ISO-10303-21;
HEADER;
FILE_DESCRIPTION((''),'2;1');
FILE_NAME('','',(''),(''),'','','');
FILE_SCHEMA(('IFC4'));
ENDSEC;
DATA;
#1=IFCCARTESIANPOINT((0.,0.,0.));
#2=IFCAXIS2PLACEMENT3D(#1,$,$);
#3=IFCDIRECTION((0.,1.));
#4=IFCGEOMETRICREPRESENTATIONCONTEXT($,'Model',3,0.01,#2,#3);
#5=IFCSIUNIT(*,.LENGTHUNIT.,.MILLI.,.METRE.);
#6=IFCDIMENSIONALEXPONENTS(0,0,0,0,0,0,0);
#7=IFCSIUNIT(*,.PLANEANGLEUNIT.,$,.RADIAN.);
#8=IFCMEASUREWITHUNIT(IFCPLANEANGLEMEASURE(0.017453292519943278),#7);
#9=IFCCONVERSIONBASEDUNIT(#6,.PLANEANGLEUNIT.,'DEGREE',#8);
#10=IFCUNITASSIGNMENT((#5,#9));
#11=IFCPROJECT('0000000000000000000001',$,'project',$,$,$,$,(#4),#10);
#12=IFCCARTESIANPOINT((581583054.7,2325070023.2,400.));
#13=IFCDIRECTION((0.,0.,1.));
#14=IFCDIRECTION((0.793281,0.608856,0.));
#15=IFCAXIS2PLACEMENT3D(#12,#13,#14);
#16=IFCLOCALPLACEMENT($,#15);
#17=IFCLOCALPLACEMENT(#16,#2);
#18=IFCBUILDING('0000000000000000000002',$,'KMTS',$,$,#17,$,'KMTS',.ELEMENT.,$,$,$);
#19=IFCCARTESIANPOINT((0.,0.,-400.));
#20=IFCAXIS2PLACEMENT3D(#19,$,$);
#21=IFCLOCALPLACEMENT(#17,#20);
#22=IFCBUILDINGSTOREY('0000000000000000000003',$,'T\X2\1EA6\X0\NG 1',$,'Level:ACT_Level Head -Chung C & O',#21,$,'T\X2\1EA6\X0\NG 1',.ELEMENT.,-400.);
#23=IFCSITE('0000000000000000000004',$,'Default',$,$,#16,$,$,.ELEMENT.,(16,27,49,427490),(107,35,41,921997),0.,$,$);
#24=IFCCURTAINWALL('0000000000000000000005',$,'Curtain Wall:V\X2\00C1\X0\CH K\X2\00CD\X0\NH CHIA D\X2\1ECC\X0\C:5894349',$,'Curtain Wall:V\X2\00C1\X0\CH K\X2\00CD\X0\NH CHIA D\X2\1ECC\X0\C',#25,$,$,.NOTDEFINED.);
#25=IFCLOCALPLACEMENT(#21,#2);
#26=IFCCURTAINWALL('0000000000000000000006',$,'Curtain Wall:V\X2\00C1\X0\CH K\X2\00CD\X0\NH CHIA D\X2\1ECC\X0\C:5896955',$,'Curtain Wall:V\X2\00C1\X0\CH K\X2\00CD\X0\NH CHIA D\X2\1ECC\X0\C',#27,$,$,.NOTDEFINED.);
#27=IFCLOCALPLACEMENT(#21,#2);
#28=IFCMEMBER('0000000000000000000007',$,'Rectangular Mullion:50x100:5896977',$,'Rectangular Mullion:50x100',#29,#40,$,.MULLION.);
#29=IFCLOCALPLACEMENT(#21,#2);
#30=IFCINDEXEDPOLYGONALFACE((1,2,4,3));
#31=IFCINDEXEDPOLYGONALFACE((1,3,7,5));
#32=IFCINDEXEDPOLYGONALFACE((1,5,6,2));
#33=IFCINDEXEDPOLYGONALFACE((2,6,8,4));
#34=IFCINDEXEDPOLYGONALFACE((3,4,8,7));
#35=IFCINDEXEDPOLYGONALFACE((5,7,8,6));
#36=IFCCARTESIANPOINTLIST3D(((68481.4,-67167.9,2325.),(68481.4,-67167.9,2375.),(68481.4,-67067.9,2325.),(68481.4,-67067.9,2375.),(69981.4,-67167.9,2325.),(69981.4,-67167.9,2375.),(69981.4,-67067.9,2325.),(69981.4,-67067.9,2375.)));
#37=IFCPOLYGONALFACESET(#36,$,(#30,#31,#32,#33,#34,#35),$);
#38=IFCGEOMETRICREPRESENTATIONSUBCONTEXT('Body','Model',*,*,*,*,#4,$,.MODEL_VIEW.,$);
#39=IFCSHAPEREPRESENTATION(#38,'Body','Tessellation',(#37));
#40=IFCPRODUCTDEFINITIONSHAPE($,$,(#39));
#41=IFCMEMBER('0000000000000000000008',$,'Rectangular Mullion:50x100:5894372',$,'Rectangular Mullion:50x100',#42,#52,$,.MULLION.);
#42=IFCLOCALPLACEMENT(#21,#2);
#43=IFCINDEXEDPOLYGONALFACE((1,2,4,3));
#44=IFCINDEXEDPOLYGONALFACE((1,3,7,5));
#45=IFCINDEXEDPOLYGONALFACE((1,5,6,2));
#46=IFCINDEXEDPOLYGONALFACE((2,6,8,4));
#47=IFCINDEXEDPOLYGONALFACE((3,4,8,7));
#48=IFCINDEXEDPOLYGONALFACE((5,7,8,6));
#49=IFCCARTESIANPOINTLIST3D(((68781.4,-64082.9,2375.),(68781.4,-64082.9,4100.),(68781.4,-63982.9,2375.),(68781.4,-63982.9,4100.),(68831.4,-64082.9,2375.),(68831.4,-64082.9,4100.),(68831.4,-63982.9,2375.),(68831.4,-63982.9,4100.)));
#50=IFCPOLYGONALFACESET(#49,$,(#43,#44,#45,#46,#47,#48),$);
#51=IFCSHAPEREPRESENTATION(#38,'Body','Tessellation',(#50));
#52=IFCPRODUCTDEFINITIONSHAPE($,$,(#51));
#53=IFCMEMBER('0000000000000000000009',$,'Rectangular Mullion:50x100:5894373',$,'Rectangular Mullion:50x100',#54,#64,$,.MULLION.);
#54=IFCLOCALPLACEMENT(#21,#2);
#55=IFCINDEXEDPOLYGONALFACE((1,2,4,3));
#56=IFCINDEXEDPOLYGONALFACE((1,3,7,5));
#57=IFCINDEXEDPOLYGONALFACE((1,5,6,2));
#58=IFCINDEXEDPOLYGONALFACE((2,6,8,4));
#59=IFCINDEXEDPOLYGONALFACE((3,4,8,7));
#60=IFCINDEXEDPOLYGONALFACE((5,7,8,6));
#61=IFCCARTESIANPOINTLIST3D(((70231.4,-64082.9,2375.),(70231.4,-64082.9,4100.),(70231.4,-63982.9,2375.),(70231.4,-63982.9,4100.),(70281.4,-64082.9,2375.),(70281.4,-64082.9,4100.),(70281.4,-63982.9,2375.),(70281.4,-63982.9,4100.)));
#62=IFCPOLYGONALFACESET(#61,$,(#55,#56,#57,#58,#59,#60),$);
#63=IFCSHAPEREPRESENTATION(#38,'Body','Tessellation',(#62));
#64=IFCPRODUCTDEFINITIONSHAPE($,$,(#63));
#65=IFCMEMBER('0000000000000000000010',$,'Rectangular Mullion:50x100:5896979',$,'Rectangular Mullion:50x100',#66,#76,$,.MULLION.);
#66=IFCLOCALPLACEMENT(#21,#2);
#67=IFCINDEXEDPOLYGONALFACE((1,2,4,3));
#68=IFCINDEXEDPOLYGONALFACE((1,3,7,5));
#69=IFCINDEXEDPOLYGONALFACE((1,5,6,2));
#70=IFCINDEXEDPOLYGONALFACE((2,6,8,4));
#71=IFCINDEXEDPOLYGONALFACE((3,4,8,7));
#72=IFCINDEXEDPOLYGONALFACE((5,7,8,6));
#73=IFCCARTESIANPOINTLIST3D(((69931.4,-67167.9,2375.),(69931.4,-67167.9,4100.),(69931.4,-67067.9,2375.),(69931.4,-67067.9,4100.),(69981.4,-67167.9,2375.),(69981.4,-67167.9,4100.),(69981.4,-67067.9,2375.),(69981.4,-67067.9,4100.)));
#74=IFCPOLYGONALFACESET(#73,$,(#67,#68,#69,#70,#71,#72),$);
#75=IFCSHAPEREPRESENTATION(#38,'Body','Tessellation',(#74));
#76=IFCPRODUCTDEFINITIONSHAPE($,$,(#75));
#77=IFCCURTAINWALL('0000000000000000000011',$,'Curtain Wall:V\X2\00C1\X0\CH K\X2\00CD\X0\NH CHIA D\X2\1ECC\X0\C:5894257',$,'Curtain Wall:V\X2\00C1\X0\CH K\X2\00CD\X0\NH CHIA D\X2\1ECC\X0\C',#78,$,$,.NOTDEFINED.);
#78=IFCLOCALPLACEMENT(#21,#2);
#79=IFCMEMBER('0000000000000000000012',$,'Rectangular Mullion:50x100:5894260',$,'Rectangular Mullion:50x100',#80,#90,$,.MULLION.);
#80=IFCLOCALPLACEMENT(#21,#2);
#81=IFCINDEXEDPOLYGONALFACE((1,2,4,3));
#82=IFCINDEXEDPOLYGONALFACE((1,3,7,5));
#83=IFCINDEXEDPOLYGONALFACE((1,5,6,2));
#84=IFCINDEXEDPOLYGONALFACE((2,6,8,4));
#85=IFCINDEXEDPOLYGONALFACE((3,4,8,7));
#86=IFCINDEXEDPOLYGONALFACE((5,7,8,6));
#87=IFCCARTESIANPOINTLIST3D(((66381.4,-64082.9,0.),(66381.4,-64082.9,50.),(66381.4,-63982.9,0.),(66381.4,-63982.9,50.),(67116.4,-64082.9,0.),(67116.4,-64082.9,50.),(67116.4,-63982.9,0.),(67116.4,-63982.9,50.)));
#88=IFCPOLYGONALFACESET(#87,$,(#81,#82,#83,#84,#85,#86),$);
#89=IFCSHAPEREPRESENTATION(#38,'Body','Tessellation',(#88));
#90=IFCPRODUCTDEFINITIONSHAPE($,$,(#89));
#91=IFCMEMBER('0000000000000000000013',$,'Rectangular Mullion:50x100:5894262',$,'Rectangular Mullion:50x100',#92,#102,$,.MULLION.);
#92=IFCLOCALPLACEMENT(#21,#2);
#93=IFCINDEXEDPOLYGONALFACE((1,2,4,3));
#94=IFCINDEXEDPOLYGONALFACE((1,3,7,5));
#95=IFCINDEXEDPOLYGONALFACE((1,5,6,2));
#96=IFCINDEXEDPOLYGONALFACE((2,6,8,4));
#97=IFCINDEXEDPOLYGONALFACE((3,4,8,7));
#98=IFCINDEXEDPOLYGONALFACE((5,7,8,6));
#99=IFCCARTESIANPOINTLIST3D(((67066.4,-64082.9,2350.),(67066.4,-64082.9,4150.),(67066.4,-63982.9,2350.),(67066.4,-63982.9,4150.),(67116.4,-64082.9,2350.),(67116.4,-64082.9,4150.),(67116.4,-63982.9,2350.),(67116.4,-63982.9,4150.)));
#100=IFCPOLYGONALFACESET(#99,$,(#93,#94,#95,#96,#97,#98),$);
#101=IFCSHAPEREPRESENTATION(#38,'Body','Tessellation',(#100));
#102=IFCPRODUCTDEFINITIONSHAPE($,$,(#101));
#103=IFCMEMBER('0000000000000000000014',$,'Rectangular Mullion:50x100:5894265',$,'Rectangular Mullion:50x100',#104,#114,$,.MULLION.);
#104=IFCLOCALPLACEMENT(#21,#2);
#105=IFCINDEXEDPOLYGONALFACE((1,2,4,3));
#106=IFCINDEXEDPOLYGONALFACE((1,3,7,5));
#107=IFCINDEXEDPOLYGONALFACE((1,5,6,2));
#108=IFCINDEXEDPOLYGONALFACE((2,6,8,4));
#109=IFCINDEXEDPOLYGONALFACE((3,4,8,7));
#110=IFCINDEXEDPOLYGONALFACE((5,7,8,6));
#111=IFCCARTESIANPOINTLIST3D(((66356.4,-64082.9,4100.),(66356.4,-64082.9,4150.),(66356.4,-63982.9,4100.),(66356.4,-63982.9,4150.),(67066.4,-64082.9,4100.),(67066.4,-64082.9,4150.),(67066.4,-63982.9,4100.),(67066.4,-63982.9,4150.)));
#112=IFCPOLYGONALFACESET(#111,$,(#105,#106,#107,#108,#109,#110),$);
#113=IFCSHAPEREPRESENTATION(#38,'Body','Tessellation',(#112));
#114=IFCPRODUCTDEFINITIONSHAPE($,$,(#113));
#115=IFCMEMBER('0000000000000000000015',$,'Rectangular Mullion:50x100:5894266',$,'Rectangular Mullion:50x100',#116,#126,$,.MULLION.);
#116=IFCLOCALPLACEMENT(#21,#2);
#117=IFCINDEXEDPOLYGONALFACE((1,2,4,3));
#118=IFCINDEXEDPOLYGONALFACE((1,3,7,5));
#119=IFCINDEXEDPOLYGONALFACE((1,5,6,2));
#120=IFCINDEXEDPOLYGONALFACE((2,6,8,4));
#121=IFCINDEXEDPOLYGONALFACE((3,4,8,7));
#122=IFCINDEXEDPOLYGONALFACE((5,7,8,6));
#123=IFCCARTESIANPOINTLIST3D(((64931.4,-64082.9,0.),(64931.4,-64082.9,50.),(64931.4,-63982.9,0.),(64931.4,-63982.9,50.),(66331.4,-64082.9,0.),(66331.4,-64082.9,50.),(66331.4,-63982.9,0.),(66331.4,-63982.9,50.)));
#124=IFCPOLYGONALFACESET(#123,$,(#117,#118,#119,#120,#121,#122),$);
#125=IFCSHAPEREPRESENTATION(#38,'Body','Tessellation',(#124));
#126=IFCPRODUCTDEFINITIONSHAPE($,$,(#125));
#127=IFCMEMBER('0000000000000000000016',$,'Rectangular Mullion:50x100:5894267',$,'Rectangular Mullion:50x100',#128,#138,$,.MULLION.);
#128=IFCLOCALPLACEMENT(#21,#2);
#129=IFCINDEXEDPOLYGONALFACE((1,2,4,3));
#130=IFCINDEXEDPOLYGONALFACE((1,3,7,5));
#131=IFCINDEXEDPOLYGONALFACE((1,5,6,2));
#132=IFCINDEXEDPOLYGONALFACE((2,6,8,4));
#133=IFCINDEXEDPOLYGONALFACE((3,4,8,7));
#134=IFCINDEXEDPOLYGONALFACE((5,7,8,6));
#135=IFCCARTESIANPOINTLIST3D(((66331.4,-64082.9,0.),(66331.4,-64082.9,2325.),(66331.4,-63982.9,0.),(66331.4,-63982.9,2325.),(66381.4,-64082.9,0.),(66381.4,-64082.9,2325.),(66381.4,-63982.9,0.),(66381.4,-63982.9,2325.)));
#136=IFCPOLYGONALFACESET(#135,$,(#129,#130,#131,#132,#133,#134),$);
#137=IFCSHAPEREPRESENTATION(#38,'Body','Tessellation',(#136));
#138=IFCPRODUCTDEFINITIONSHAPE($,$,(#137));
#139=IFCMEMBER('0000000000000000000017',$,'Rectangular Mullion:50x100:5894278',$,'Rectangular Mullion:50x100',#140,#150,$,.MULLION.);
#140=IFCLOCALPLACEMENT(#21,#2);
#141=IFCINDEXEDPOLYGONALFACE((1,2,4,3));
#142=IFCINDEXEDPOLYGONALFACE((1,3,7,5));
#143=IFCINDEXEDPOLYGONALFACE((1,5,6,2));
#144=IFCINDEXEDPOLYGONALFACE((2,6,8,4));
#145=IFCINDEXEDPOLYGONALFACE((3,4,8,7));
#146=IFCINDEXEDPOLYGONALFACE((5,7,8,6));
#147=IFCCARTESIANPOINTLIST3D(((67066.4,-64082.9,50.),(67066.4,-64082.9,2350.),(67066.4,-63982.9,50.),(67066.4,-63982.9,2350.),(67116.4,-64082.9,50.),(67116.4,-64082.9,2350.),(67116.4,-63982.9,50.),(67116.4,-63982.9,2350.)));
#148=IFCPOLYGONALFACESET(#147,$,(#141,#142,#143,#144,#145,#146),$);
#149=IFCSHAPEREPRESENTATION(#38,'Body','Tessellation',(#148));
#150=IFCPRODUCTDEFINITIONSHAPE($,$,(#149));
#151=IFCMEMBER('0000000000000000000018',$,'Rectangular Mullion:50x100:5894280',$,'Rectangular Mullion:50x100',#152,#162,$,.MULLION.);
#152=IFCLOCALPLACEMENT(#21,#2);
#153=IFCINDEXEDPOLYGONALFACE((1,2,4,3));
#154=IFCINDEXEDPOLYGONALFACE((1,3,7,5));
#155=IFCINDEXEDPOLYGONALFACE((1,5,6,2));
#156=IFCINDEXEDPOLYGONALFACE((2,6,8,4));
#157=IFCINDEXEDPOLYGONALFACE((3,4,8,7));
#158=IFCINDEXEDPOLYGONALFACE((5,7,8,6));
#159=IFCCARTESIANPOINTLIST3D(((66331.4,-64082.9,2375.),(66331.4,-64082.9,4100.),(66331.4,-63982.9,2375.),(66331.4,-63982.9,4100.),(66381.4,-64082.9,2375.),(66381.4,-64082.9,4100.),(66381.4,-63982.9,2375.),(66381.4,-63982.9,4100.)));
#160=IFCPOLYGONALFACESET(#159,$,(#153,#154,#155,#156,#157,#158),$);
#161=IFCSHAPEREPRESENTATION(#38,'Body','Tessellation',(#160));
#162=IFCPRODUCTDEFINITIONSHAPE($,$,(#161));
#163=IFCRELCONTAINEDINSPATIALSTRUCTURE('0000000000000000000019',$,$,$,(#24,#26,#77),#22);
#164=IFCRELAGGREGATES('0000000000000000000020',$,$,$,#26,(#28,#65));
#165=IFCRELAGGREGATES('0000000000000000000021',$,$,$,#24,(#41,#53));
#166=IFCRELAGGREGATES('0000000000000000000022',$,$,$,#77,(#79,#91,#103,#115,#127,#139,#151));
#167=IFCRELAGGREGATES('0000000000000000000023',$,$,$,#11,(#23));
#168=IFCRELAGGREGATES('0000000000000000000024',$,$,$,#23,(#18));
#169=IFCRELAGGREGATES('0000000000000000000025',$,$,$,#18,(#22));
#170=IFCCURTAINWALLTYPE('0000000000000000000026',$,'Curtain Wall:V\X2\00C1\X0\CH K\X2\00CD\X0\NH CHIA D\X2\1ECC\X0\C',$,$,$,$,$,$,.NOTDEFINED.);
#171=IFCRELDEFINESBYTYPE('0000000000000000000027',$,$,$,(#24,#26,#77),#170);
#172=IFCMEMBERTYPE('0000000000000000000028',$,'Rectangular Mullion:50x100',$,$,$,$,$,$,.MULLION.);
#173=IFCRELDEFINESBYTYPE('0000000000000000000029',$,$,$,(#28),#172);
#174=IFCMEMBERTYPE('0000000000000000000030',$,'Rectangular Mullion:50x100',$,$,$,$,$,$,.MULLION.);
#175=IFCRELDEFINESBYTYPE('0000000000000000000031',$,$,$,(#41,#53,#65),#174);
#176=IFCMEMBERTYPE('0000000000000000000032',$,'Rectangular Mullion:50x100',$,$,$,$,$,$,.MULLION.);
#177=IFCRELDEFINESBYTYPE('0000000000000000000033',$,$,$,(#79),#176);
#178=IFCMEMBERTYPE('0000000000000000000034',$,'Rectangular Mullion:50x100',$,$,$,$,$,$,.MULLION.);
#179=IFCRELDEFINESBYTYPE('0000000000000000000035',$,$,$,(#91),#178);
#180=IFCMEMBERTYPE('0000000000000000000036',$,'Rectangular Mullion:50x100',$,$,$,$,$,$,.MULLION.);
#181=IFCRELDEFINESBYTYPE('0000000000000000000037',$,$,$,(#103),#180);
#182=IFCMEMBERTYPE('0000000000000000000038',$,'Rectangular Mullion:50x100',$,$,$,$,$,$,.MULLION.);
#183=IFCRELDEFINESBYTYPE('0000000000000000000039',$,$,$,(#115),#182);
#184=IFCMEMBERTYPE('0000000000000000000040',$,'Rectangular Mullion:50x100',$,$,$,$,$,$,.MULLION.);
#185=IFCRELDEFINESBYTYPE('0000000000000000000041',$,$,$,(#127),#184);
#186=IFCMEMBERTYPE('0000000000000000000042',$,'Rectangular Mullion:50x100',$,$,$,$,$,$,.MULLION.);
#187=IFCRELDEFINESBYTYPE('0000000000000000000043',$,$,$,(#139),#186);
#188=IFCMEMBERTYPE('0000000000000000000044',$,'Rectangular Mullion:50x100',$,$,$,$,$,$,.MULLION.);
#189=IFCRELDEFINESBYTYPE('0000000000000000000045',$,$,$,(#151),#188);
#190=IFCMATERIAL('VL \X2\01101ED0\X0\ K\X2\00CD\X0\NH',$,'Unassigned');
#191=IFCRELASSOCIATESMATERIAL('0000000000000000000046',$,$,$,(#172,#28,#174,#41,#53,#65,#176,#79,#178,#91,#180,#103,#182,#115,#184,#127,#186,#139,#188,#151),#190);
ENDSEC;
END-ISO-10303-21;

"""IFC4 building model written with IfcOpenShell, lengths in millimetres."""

from ifc_helpers import new_model, entity, si_unit, converted_unit, direction, frame, origin, place, context, subcontext, project, spatial, indexed_curve, outline, extrude, source, transform, mapped, material, type_object, type_shapes, element, aggregate, save


model = new_model("IFC4")

# Units and contexts
model_context = context("Model", 3, precision=0.01, world=origin(), true_north=direction((0.0, 1.0)))
body_context = subcontext(model_context, "Body", "Model", "MODEL_VIEW")
ifc_project = project(units=[si_unit("LENGTHUNIT", "METRE", prefix="MILLI"), converted_unit("PLANEANGLEUNIT", "DEGREE", entity("IfcPlaneAngleMeasure", 0.017453292519943278), si_unit("PLANEANGLEUNIT", "RADIAN"), dimensions=[0, 0, 0, 0, 0, 0, 0])], contexts=[model_context])

# Site, building, storey
site_placement = place(None, frame((581583054.7, 2325070023.2, 400.0), z_axis=(0.0, 0.0, 1.0), x_axis=(0.793281, 0.608856, 0.0)))
site = spatial("IfcSite", under=ifc_project, at=site_placement, Name="Default", CompositionType="ELEMENT", RefLatitude=(16, 27, 49, 427490), RefLongitude=(107, 35, 41, 921997), RefElevation=0.0)
building_placement = place(site_placement, origin())
building = spatial("IfcBuilding", under=site, at=building_placement, Name="KMTS", LongName="KMTS", CompositionType="ELEMENT")
storey_placement = place(building_placement, frame((0.0, 0.0, -400.0)))
storey = spatial("IfcBuildingStorey", under=building, at=storey_placement, Name="TẦNG 1", ObjectType="Level:ACT_Level Head -Chung C & O", LongName="TẦNG 1", CompositionType="ELEMENT", Elevation=-400.0)

# Curtain wall
curtain_wall_type = type_object("IfcCurtainWallType", Name="Curtain Wall:VÁCH KÍNH CHIA DỌC", PredefinedType="NOTDEFINED")
curtain_wall_1_placement = place(storey_placement, frame((0.0, 0.0, 400.0)))
curtain_wall_1 = element("IfcCurtainWall", 1, at=curtain_wall_1_placement, inside=storey, type_object=curtain_wall_type, Name="Curtain Wall:VÁCH KÍNH CHIA DỌC:5894349", ObjectType="Curtain Wall:VÁCH KÍNH CHIA DỌC", PredefinedType="NOTDEFINED")
ifc_material_1 = material(Name="VL ĐỐ KÍNH", Category="Unassigned")

# Curtain wall
curtain_wall_2_placement = place(storey_placement, frame((0.0, 0.0, 400.0)))
curtain_wall_2 = element("IfcCurtainWall", 2, at=curtain_wall_2_placement, inside=storey, type_object=curtain_wall_type, Name="Curtain Wall:VÁCH KÍNH CHIA DỌC:5896955", ObjectType="Curtain Wall:VÁCH KÍNH CHIA DỌC", PredefinedType="NOTDEFINED")

# Members
member_type_1 = type_object("IfcMemberType", Name="Rectangular Mullion:50x100", PredefinedType="MULLION", material=ifc_material_1)
shared_shape_1 = source(origin(), body_context, "Body", "SweptSolid", [
    extrude(outline(indexed_curve([(-25.0, -50.0), (25.0, -50.0), (25.0, 50.0), (-25.0, 50.0), (-25.0, -50.0)], self_intersect=False)), frame((0.0, 0.0, -1500.0), z_axis=(0.0, 0.0, 1.0), x_axis=(-1.0, 0.0, 0.0)), (0.0, 0.0, 1.0), 1500.0),
])
type_shapes(member_type_1, [shared_shape_1])
member_1_placement = place(curtain_wall_2_placement, frame((69981.4, -67117.9, 1950.0), z_axis=(1.0, 0.0, 0.0), x_axis=(0.0, 0.0, 1.0)))
member_1 = element("IfcMember", 3, at=member_1_placement, type_object=member_type_1, material=ifc_material_1, Name="Rectangular Mullion:50x100:5896977", ObjectType="Rectangular Mullion:50x100", PredefinedType="MULLION", context=body_context, shape_type="MappedRepresentation", body=[
    mapped(shared_shape_1, transform((0.0, 0.0, 0.0), scale=1.0)),
])
member_type_2 = type_object("IfcMemberType", Name="Rectangular Mullion:50x100", PredefinedType="MULLION", material=ifc_material_1)
shared_shape_2 = source(origin(), body_context, "Body", "SweptSolid", [
    extrude(outline(indexed_curve([(-25.0, -50.0), (25.0, -50.0), (25.0, 50.0), (-25.0, 50.0), (-25.0, -50.0)], self_intersect=False)), frame((0.0, 0.0, -1725.0), z_axis=(0.0, 0.0, 1.0), x_axis=(-1.0, 0.0, 0.0)), (0.0, 0.0, 1.0), 1725.0),
])
type_shapes(member_type_2, [shared_shape_2])
member_2_placement = place(curtain_wall_1_placement, frame((68806.4, -64032.9, 1975.0), z_axis=(0.0, 0.0, -1.0), x_axis=(1.0, 0.0, 0.0)))
member_2 = element("IfcMember", 4, at=member_2_placement, type_object=member_type_2, material=ifc_material_1, Name="Rectangular Mullion:50x100:5894372", ObjectType="Rectangular Mullion:50x100", PredefinedType="MULLION", context=body_context, shape_type="MappedRepresentation", body=[
    mapped(shared_shape_2, transform((0.0, 0.0, 0.0), scale=1.0)),
])
member_3_placement = place(curtain_wall_1_placement, frame((70256.4, -64032.9, 1975.0), z_axis=(0.0, 0.0, -1.0), x_axis=(1.0, 0.0, 0.0)))
member_3 = element("IfcMember", 5, at=member_3_placement, type_object=member_type_2, material=ifc_material_1, Name="Rectangular Mullion:50x100:5894373", ObjectType="Rectangular Mullion:50x100", PredefinedType="MULLION", context=body_context, shape_type="MappedRepresentation", body=[
    mapped(shared_shape_2, transform((0.0, 0.0, 0.0), scale=1.0)),
])
member_4_placement = place(curtain_wall_2_placement, frame((69956.4, -67117.9, 1975.0), z_axis=(0.0, 0.0, -1.0), x_axis=(1.0, 0.0, 0.0)))
member_4 = element("IfcMember", 6, at=member_4_placement, type_object=member_type_2, material=ifc_material_1, Name="Rectangular Mullion:50x100:5896979", ObjectType="Rectangular Mullion:50x100", PredefinedType="MULLION", context=body_context, shape_type="MappedRepresentation", body=[
    mapped(shared_shape_2, transform((0.0, 0.0, 0.0), scale=1.0)),
])

# Curtain wall, members
curtain_wall_3_placement = place(storey_placement, frame((0.0, 0.0, 400.0)))
curtain_wall_3 = element("IfcCurtainWall", 7, at=curtain_wall_3_placement, inside=storey, type_object=curtain_wall_type, Name="Curtain Wall:VÁCH KÍNH CHIA DỌC:5894257", ObjectType="Curtain Wall:VÁCH KÍNH CHIA DỌC", PredefinedType="NOTDEFINED")
member_type_3 = type_object("IfcMemberType", Name="Rectangular Mullion:50x100", PredefinedType="MULLION", material=ifc_material_1)
shared_shape_3 = source(origin(), body_context, "Body", "SweptSolid", [
    extrude(outline(indexed_curve([(-25.0, -50.0), (25.0, -50.0), (25.0, 50.0), (-25.0, 50.0), (-25.0, -50.0)], self_intersect=False)), frame((-25.0, 0.0, -735.0), z_axis=(0.0, 0.0, 1.0), x_axis=(-1.0, 0.0, 0.0)), (0.0, 0.0, 1.0), 735.0),
])
type_shapes(member_type_3, [shared_shape_3])
member_5_placement = place(curtain_wall_3_placement, frame((67116.4, -64032.9, -400.0), z_axis=(1.0, 0.0, 0.0), x_axis=(0.0, 0.0, -1.0)))
member_5 = element("IfcMember", 8, at=member_5_placement, type_object=member_type_3, material=ifc_material_1, Name="Rectangular Mullion:50x100:5894260", ObjectType="Rectangular Mullion:50x100", PredefinedType="MULLION", context=body_context, shape_type="MappedRepresentation", body=[
    mapped(shared_shape_3, transform((0.0, 0.0, 0.0), scale=1.0)),
])
member_type_4 = type_object("IfcMemberType", Name="Rectangular Mullion:50x100", PredefinedType="MULLION", material=ifc_material_1)
shared_shape_4 = source(origin(), body_context, "Body", "SweptSolid", [
    extrude(outline(indexed_curve([(-25.0, -50.0), (25.0, -50.0), (25.0, 50.0), (-25.0, 50.0), (-25.0, -50.0)], self_intersect=False)), frame((-25.0, 0.0, -1800.0), z_axis=(0.0, 0.0, 1.0), x_axis=(-1.0, 0.0, 0.0)), (0.0, 0.0, 1.0), 1800.0),
])
type_shapes(member_type_4, [shared_shape_4])
member_6_placement = place(curtain_wall_3_placement, frame((67116.4, -64032.9, 3750.0)))
member_6 = element("IfcMember", 9, at=member_6_placement, type_object=member_type_4, material=ifc_material_1, Name="Rectangular Mullion:50x100:5894262", ObjectType="Rectangular Mullion:50x100", PredefinedType="MULLION", context=body_context, shape_type="MappedRepresentation", body=[
    mapped(shared_shape_4, transform((0.0, 0.0, 0.0), scale=1.0)),
])
member_type_5 = type_object("IfcMemberType", Name="Rectangular Mullion:50x100", PredefinedType="MULLION", material=ifc_material_1)
shared_shape_5 = source(origin(), body_context, "Body", "SweptSolid", [
    extrude(outline(indexed_curve([(-25.0, -50.0), (25.0, -50.0), (25.0, 50.0), (-25.0, 50.0), (-25.0, -50.0)], self_intersect=False)), frame((-25.0, 0.0, -710.0), z_axis=(0.0, 0.0, 1.0), x_axis=(-1.0, 0.0, 0.0)), (0.0, 0.0, 1.0), 710.0),
])
type_shapes(member_type_5, [shared_shape_5])
member_7_placement = place(curtain_wall_3_placement, frame((66356.4, -64032.9, 3750.0), z_axis=(-1.0, 0.0, 0.0), x_axis=(0.0, 0.0, 1.0)))
member_7 = element("IfcMember", 10, at=member_7_placement, type_object=member_type_5, material=ifc_material_1, Name="Rectangular Mullion:50x100:5894265", ObjectType="Rectangular Mullion:50x100", PredefinedType="MULLION", context=body_context, shape_type="MappedRepresentation", body=[
    mapped(shared_shape_5, transform((0.0, 0.0, 0.0), scale=1.0)),
])
member_type_6 = type_object("IfcMemberType", Name="Rectangular Mullion:50x100", PredefinedType="MULLION", material=ifc_material_1)
shared_shape_6 = source(origin(), body_context, "Body", "SweptSolid", [
    extrude(outline(indexed_curve([(-25.0, -50.0), (25.0, -50.0), (25.0, 50.0), (-25.0, 50.0), (-25.0, -50.0)], self_intersect=False)), frame((-25.0, 0.0, -1400.0), z_axis=(0.0, 0.0, 1.0), x_axis=(-1.0, 0.0, 0.0)), (0.0, 0.0, 1.0), 1400.0),
])
type_shapes(member_type_6, [shared_shape_6])
member_8_placement = place(curtain_wall_3_placement, frame((66331.4, -64032.9, -400.0), z_axis=(1.0, 0.0, 0.0), x_axis=(0.0, 0.0, -1.0)))
member_8 = element("IfcMember", 11, at=member_8_placement, type_object=member_type_6, material=ifc_material_1, Name="Rectangular Mullion:50x100:5894266", ObjectType="Rectangular Mullion:50x100", PredefinedType="MULLION", context=body_context, shape_type="MappedRepresentation", body=[
    mapped(shared_shape_6, transform((0.0, 0.0, 0.0), scale=1.0)),
])
member_type_7 = type_object("IfcMemberType", Name="Rectangular Mullion:50x100", PredefinedType="MULLION", material=ifc_material_1)
shared_shape_7 = source(origin(), body_context, "Body", "SweptSolid", [
    extrude(outline(indexed_curve([(-25.0, -50.0), (25.0, -50.0), (25.0, 50.0), (-25.0, 50.0), (-25.0, -50.0)], self_intersect=False)), frame((0.0, 0.0, -2325.0), z_axis=(0.0, 0.0, 1.0), x_axis=(-1.0, 0.0, 0.0)), (0.0, 0.0, 1.0), 2325.0),
])
type_shapes(member_type_7, [shared_shape_7])
member_9_placement = place(curtain_wall_3_placement, frame((66356.4, -64032.9, -400.0), z_axis=(0.0, 0.0, -1.0), x_axis=(-1.0, 0.0, 0.0)))
member_9 = element("IfcMember", 12, at=member_9_placement, type_object=member_type_7, material=ifc_material_1, Name="Rectangular Mullion:50x100:5894267", ObjectType="Rectangular Mullion:50x100", PredefinedType="MULLION", context=body_context, shape_type="MappedRepresentation", body=[
    mapped(shared_shape_7, transform((0.0, 0.0, 0.0), scale=1.0)),
])
member_type_8 = type_object("IfcMemberType", Name="Rectangular Mullion:50x100", PredefinedType="MULLION", material=ifc_material_1)
shared_shape_8 = source(origin(), body_context, "Body", "SweptSolid", [
    extrude(outline(indexed_curve([(-25.0, -50.0), (25.0, -50.0), (25.0, 50.0), (-25.0, 50.0), (-25.0, -50.0)], self_intersect=False)), frame((-25.0, 0.0, -2300.0), z_axis=(0.0, 0.0, 1.0), x_axis=(-1.0, 0.0, 0.0)), (0.0, 0.0, 1.0), 2300.0),
])
type_shapes(member_type_8, [shared_shape_8])
member_10_placement = place(curtain_wall_3_placement, frame((67116.4, -64032.9, 1950.0)))
member_10 = element("IfcMember", 13, at=member_10_placement, type_object=member_type_8, material=ifc_material_1, Name="Rectangular Mullion:50x100:5894278", ObjectType="Rectangular Mullion:50x100", PredefinedType="MULLION", context=body_context, shape_type="MappedRepresentation", body=[
    mapped(shared_shape_8, transform((0.0, 0.0, 0.0), scale=1.0)),
])
member_type_9 = type_object("IfcMemberType", Name="Rectangular Mullion:50x100", PredefinedType="MULLION", material=ifc_material_1)
shared_shape_9 = source(origin(), body_context, "Body", "SweptSolid", [
    extrude(outline(indexed_curve([(-25.0, -50.0), (25.0, -50.0), (25.0, 50.0), (-25.0, 50.0), (-25.0, -50.0)], self_intersect=False)), frame((0.0, 0.0, -1725.0), z_axis=(0.0, 0.0, 1.0), x_axis=(-1.0, 0.0, 0.0)), (0.0, 0.0, 1.0), 1725.0),
])
type_shapes(member_type_9, [shared_shape_9])
member_11_placement = place(curtain_wall_3_placement, frame((66356.4, -64032.9, 1975.0), z_axis=(0.0, 0.0, -1.0), x_axis=(-1.0, 0.0, 0.0)))
member_11 = element("IfcMember", 14, at=member_11_placement, type_object=member_type_9, material=ifc_material_1, Name="Rectangular Mullion:50x100:5894280", ObjectType="Rectangular Mullion:50x100", PredefinedType="MULLION", context=body_context, shape_type="MappedRepresentation", body=[
    mapped(shared_shape_9, transform((0.0, 0.0, 0.0), scale=1.0)),
])

aggregate(curtain_wall_2, [member_1, member_4])

aggregate(curtain_wall_1, [member_2, member_3])
aggregate(curtain_wall_3, [member_5, member_6, member_7, member_8, member_9, member_10, member_11])

save(model, "model.ifc")
